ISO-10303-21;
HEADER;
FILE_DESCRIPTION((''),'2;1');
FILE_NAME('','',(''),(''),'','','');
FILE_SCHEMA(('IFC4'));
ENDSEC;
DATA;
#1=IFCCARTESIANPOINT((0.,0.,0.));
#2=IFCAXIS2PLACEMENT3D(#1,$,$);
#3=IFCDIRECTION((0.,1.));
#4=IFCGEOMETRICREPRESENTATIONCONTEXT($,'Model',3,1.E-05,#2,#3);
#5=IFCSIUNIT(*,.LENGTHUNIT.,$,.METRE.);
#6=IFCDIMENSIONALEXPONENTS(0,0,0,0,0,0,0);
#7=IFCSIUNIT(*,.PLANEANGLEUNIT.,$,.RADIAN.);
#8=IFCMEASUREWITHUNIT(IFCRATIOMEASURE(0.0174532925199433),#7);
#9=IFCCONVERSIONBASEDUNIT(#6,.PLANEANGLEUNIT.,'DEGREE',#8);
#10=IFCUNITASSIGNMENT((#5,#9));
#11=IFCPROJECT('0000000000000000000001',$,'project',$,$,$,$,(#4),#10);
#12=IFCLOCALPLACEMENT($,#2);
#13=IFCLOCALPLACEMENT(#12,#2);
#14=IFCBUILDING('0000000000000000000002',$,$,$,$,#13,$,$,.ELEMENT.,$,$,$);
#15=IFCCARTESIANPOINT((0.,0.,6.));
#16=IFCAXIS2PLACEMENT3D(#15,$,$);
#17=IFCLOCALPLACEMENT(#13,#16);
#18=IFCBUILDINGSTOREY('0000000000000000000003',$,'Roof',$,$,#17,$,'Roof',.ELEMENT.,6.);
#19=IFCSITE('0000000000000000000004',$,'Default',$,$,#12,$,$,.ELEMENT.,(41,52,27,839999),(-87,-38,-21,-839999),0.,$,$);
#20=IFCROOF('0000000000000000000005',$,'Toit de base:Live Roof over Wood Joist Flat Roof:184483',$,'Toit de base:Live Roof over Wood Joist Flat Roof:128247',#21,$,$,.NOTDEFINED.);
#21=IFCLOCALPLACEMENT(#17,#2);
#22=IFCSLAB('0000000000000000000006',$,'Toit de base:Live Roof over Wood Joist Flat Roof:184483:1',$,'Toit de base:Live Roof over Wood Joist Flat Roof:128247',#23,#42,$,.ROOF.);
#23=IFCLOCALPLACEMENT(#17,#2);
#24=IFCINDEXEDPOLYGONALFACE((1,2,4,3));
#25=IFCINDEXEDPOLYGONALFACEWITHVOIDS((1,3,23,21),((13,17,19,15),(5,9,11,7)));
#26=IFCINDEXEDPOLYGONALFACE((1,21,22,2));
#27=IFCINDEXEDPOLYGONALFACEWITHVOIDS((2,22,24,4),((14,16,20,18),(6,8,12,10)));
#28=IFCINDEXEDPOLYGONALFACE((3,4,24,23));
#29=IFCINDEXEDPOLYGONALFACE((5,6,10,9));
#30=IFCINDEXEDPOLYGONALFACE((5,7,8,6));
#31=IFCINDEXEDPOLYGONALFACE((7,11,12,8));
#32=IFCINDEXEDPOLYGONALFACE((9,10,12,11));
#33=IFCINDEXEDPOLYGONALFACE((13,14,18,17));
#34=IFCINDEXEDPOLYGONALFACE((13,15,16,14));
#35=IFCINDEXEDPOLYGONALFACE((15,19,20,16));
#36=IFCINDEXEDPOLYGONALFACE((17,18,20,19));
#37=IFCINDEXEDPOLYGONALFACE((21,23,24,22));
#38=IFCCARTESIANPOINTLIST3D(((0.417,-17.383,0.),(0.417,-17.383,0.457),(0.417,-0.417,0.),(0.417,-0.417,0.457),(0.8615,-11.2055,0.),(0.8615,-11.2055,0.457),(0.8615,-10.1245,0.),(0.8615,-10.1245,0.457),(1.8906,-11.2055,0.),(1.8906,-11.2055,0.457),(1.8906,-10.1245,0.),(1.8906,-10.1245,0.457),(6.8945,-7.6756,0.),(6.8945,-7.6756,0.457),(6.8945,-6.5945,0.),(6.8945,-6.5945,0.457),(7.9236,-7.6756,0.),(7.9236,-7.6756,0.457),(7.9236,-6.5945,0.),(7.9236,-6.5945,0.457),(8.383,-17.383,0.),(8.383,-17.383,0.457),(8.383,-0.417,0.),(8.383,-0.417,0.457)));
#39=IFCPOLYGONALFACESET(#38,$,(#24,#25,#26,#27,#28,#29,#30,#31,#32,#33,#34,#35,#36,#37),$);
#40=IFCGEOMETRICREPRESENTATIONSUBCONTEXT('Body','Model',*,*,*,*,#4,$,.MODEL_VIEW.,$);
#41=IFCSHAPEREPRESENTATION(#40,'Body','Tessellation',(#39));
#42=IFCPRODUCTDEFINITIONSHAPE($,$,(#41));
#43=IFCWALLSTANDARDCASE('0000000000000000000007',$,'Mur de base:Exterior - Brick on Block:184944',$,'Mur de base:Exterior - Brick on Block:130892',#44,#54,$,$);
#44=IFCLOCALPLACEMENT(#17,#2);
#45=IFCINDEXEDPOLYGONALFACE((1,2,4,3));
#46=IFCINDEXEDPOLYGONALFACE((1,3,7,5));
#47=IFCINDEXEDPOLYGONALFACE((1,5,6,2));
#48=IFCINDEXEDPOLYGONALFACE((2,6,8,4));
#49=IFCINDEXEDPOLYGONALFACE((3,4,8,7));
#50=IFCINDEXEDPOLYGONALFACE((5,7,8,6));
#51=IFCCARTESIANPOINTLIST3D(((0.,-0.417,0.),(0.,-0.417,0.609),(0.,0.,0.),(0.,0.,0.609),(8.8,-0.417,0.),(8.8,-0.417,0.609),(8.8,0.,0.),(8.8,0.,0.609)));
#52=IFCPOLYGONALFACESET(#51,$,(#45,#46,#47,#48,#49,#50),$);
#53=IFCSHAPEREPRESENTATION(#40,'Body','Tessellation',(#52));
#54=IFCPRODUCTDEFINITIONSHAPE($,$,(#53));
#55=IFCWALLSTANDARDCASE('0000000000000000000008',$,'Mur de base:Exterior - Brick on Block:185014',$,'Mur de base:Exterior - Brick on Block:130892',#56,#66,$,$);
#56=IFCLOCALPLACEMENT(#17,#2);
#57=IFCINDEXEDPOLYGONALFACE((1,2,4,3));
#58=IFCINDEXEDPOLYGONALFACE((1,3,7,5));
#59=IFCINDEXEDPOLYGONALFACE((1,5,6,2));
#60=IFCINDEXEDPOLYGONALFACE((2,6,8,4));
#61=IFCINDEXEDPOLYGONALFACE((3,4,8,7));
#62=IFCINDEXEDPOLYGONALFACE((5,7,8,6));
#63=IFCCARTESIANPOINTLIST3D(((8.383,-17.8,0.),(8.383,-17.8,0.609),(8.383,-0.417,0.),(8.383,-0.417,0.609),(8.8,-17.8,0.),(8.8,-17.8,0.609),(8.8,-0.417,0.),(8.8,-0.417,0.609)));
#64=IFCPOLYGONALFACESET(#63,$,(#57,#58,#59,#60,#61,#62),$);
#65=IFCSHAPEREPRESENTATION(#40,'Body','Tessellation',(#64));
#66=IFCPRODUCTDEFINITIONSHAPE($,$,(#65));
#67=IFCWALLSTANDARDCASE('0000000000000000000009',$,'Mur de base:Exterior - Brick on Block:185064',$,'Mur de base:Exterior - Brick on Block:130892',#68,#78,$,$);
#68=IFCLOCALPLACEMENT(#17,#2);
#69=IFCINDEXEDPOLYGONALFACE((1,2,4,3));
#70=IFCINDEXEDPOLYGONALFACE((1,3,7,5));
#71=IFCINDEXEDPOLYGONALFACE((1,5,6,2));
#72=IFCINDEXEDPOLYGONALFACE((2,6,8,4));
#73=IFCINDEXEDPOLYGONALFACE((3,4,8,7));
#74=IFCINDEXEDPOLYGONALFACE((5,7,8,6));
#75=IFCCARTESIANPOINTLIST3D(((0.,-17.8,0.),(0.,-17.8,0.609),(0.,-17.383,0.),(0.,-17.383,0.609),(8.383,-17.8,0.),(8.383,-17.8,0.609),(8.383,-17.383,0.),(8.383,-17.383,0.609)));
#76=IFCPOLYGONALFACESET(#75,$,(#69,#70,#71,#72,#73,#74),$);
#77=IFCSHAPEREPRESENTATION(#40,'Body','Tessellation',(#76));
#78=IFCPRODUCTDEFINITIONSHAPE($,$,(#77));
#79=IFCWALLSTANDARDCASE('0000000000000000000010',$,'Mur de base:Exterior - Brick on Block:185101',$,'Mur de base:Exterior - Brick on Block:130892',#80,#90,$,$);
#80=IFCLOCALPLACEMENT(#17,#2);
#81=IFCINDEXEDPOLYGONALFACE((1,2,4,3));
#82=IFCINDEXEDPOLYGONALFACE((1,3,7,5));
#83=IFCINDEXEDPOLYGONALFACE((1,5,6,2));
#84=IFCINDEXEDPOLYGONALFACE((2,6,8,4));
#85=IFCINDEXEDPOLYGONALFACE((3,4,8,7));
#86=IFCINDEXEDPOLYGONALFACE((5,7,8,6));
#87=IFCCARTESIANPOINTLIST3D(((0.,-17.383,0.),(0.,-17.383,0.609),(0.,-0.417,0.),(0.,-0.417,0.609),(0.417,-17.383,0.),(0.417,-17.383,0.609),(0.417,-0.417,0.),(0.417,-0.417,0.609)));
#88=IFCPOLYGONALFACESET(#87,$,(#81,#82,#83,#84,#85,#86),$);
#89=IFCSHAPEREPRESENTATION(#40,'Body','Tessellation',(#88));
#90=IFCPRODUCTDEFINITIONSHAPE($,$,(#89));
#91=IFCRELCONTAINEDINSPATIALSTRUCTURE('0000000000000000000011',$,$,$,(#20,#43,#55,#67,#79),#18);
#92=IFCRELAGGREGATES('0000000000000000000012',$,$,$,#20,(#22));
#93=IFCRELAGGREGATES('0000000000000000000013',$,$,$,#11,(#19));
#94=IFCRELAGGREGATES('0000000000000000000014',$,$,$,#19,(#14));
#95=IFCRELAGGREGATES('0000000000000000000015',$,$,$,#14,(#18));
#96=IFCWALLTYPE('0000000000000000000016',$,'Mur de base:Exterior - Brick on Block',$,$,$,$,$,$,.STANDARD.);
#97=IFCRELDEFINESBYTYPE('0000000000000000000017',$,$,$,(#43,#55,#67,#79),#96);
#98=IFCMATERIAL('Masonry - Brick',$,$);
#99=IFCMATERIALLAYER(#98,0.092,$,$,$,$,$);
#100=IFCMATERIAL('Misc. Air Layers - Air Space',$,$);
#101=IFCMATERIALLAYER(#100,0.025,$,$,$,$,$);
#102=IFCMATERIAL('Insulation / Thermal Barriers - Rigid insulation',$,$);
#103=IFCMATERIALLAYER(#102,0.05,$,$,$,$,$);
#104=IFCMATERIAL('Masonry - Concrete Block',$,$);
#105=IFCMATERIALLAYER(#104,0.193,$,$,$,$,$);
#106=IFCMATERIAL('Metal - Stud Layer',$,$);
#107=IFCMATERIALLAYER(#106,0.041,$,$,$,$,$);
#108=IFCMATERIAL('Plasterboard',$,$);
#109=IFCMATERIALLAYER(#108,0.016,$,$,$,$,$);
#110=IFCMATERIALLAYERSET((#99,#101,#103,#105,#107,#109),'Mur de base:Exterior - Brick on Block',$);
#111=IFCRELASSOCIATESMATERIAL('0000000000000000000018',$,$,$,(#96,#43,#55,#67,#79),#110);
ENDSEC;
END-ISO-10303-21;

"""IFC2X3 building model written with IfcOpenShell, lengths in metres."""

from ifc_helpers import new_model, entity, si_unit, converted_unit, direction, frame, frame_2d, origin, place, context, subcontext, project, spatial, rectangle, extrude, material, layer, layer_set, layer_usage, type_object, element, aggregate, save


model = new_model("IFC2X3")

# Units and contexts
model_context = context("Model", 3, precision=1e-05, world=origin(), true_north=direction((0.0, 1.0)))
body_context = subcontext(model_context, "Body", "Model", "MODEL_VIEW")
ifc_project = project(units=[si_unit("LENGTHUNIT", "METRE"), converted_unit("PLANEANGLEUNIT", "DEGREE", entity("IfcRatioMeasure", 0.0174532925199433), si_unit("PLANEANGLEUNIT", "RADIAN"), dimensions=[0, 0, 0, 0, 0, 0, 0])], contexts=[model_context])

# Site, building, storey
site_placement = place(None, origin())
site = spatial("IfcSite", under=ifc_project, at=site_placement, Name="Default", CompositionType="ELEMENT", RefLatitude=(41, 52, 27, 839999), RefLongitude=(-87, -38, -21, -839999), RefElevation=0.0)
building_placement = place(site_placement, origin())
building = spatial("IfcBuilding", under=site, at=building_placement, CompositionType="ELEMENT")
storey_placement = place(building_placement, frame((0.0, 0.0, 6.0)))
storey = spatial("IfcBuildingStorey", under=building, at=storey_placement, Name="Roof", LongName="Roof", CompositionType="ELEMENT", Elevation=6.0)

# Roof, slab, openings
roof_placement = place(storey_placement, origin())
roof = element("IfcRoof", 1, at=roof_placement, inside=storey, Name="Toit de base:Live Roof over Wood Joist Flat Roof:184483", ObjectType="Toit de base:Live Roof over Wood Joist Flat Roof:128247", ShapeType="NOTDEFINED")
slab_placement = place(storey_placement, origin())
slab = element("IfcSlab", 2, at=slab_placement, Name="Toit de base:Live Roof over Wood Joist Flat Roof:184483:1", ObjectType="Toit de base:Live Roof over Wood Joist Flat Roof:128247", PredefinedType="ROOF", context=body_context, shape_type="SweptSolid", body=[
    extrude(rectangle(XDim=16.966, YDim=7.966, at=frame_2d((0.0, 0.0), x_axis=(1.0, 0.0))), frame((4.4, -8.9, 0.0), z_axis=(0.0, 0.0, 1.0), x_axis=(0.0, -1.0, 0.0)), (0.0, 0.0, 1.0), 0.457),
])
opening_1_placement = place(storey_placement, origin())
element("IfcOpeningElement", 3, at=opening_1_placement, cuts=slab, ObjectType="Opening", context=body_context, shape_type="SweptSolid", body=[
    extrude(rectangle(XDim=1.0291, YDim=1.0811, at=frame_2d((0.0, 0.0), x_axis=(1.0, 0.0))), frame((1.376, -10.665, 0.0), z_axis=(0.0, 0.0, 1.0), x_axis=(-1.0, 0.0, 0.0)), (0.0, 0.0, 1.0), 0.457),
])
opening_2_placement = place(storey_placement, origin())
element("IfcOpeningElement", 4, at=opening_2_placement, cuts=slab, ObjectType="Opening", context=body_context, shape_type="SweptSolid", body=[
    extrude(rectangle(XDim=1.0291, YDim=1.0811, at=frame_2d((0.0, 0.0), x_axis=(1.0, 0.0))), frame((7.409, -7.135, 0.0), z_axis=(0.0, 0.0, 1.0), x_axis=(-1.0, 0.0, 0.0)), (0.0, 0.0, 1.0), 0.457),
])
aggregate(roof, [slab])

# Walls
ifc_material_1 = material(Name="Masonry - Brick")
ifc_layer_1 = layer(ifc_material_1, 0.092)
ifc_material_2 = material(Name="Misc. Air Layers - Air Space")
ifc_layer_2 = layer(ifc_material_2, 0.025)
ifc_material_3 = material(Name="Insulation / Thermal Barriers - Rigid insulation")
ifc_layer_3 = layer(ifc_material_3, 0.05)
ifc_material_4 = material(Name="Masonry - Concrete Block")
ifc_layer_4 = layer(ifc_material_4, 0.193)
ifc_material_5 = material(Name="Metal - Stud Layer")
ifc_layer_5 = layer(ifc_material_5, 0.041)
ifc_material_6 = material(Name="Plasterboard")
ifc_layer_6 = layer(ifc_material_6, 0.016)
ifc_layer_set = layer_set([ifc_layer_1, ifc_layer_2, ifc_layer_3, ifc_layer_4, ifc_layer_5, ifc_layer_6], Name="Mur de base:Exterior - Brick on Block")
ifc_layer_usage_1 = layer_usage(ifc_layer_set, "AXIS2", "NEGATIVE", 0.2085)
wall_type = type_object("IfcWallType", Name="Mur de base:Exterior - Brick on Block", PredefinedType="STANDARD", material=ifc_layer_set)
wall_1_placement = place(storey_placement, frame((0.0, -0.2085, 0.0)))
element("IfcWallStandardCase", 5, at=wall_1_placement, inside=storey, type_object=wall_type, material=ifc_layer_usage_1, Name="Mur de base:Exterior - Brick on Block:184944", ObjectType="Mur de base:Exterior - Brick on Block:130892", context=body_context, shape_type="SweptSolid", body=[
    extrude(rectangle(XDim=8.8, YDim=0.417, at=frame_2d((4.4, 0.0), x_axis=(-1.0, 0.0))), origin(), (0.0, 0.0, 1.0), 0.609),
])
ifc_layer_usage_2 = layer_usage(ifc_layer_set, "AXIS2", "NEGATIVE", 0.2085)
wall_2_placement = place(storey_placement, frame((8.5915, -0.417, 0.0), z_axis=(0.0, 0.0, 1.0), x_axis=(0.0, -1.0, 0.0)))
element("IfcWallStandardCase", 6, at=wall_2_placement, inside=storey, type_object=wall_type, material=ifc_layer_usage_2, Name="Mur de base:Exterior - Brick on Block:185014", ObjectType="Mur de base:Exterior - Brick on Block:130892", context=body_context, shape_type="SweptSolid", body=[
    extrude(rectangle(XDim=17.383, YDim=0.417, at=frame_2d((8.6915, 0.0), x_axis=(-1.0, 0.0))), origin(), (0.0, 0.0, 1.0), 0.609),
])
ifc_layer_usage_3 = layer_usage(ifc_layer_set, "AXIS2", "NEGATIVE", 0.2085)
wall_3_placement = place(storey_placement, frame((8.383, -17.5915, 0.0), z_axis=(0.0, 0.0, 1.0), x_axis=(-1.0, 0.0, 0.0)))
element("IfcWallStandardCase", 7, at=wall_3_placement, inside=storey, type_object=wall_type, material=ifc_layer_usage_3, Name="Mur de base:Exterior - Brick on Block:185064", ObjectType="Mur de base:Exterior - Brick on Block:130892", context=body_context, shape_type="SweptSolid", body=[
    extrude(rectangle(XDim=8.383, YDim=0.417, at=frame_2d((4.1915, 0.0), x_axis=(-1.0, 0.0))), origin(), (0.0, 0.0, 1.0), 0.609),
])
ifc_layer_usage_4 = layer_usage(ifc_layer_set, "AXIS2", "NEGATIVE", 0.2085)
wall_4_placement = place(storey_placement, frame((0.2085, -17.383, 0.0), z_axis=(0.0, 0.0, 1.0), x_axis=(0.0, 1.0, 0.0)))
element("IfcWallStandardCase", 8, at=wall_4_placement, inside=storey, type_object=wall_type, material=ifc_layer_usage_4, Name="Mur de base:Exterior - Brick on Block:185101", ObjectType="Mur de base:Exterior - Brick on Block:130892", context=body_context, shape_type="SweptSolid", body=[
    extrude(rectangle(XDim=16.966, YDim=0.417, at=frame_2d((8.483, 0.0), x_axis=(-1.0, 0.0))), origin(), (0.0, 0.0, 1.0), 0.609),
])

save(model, "model.ifc")
